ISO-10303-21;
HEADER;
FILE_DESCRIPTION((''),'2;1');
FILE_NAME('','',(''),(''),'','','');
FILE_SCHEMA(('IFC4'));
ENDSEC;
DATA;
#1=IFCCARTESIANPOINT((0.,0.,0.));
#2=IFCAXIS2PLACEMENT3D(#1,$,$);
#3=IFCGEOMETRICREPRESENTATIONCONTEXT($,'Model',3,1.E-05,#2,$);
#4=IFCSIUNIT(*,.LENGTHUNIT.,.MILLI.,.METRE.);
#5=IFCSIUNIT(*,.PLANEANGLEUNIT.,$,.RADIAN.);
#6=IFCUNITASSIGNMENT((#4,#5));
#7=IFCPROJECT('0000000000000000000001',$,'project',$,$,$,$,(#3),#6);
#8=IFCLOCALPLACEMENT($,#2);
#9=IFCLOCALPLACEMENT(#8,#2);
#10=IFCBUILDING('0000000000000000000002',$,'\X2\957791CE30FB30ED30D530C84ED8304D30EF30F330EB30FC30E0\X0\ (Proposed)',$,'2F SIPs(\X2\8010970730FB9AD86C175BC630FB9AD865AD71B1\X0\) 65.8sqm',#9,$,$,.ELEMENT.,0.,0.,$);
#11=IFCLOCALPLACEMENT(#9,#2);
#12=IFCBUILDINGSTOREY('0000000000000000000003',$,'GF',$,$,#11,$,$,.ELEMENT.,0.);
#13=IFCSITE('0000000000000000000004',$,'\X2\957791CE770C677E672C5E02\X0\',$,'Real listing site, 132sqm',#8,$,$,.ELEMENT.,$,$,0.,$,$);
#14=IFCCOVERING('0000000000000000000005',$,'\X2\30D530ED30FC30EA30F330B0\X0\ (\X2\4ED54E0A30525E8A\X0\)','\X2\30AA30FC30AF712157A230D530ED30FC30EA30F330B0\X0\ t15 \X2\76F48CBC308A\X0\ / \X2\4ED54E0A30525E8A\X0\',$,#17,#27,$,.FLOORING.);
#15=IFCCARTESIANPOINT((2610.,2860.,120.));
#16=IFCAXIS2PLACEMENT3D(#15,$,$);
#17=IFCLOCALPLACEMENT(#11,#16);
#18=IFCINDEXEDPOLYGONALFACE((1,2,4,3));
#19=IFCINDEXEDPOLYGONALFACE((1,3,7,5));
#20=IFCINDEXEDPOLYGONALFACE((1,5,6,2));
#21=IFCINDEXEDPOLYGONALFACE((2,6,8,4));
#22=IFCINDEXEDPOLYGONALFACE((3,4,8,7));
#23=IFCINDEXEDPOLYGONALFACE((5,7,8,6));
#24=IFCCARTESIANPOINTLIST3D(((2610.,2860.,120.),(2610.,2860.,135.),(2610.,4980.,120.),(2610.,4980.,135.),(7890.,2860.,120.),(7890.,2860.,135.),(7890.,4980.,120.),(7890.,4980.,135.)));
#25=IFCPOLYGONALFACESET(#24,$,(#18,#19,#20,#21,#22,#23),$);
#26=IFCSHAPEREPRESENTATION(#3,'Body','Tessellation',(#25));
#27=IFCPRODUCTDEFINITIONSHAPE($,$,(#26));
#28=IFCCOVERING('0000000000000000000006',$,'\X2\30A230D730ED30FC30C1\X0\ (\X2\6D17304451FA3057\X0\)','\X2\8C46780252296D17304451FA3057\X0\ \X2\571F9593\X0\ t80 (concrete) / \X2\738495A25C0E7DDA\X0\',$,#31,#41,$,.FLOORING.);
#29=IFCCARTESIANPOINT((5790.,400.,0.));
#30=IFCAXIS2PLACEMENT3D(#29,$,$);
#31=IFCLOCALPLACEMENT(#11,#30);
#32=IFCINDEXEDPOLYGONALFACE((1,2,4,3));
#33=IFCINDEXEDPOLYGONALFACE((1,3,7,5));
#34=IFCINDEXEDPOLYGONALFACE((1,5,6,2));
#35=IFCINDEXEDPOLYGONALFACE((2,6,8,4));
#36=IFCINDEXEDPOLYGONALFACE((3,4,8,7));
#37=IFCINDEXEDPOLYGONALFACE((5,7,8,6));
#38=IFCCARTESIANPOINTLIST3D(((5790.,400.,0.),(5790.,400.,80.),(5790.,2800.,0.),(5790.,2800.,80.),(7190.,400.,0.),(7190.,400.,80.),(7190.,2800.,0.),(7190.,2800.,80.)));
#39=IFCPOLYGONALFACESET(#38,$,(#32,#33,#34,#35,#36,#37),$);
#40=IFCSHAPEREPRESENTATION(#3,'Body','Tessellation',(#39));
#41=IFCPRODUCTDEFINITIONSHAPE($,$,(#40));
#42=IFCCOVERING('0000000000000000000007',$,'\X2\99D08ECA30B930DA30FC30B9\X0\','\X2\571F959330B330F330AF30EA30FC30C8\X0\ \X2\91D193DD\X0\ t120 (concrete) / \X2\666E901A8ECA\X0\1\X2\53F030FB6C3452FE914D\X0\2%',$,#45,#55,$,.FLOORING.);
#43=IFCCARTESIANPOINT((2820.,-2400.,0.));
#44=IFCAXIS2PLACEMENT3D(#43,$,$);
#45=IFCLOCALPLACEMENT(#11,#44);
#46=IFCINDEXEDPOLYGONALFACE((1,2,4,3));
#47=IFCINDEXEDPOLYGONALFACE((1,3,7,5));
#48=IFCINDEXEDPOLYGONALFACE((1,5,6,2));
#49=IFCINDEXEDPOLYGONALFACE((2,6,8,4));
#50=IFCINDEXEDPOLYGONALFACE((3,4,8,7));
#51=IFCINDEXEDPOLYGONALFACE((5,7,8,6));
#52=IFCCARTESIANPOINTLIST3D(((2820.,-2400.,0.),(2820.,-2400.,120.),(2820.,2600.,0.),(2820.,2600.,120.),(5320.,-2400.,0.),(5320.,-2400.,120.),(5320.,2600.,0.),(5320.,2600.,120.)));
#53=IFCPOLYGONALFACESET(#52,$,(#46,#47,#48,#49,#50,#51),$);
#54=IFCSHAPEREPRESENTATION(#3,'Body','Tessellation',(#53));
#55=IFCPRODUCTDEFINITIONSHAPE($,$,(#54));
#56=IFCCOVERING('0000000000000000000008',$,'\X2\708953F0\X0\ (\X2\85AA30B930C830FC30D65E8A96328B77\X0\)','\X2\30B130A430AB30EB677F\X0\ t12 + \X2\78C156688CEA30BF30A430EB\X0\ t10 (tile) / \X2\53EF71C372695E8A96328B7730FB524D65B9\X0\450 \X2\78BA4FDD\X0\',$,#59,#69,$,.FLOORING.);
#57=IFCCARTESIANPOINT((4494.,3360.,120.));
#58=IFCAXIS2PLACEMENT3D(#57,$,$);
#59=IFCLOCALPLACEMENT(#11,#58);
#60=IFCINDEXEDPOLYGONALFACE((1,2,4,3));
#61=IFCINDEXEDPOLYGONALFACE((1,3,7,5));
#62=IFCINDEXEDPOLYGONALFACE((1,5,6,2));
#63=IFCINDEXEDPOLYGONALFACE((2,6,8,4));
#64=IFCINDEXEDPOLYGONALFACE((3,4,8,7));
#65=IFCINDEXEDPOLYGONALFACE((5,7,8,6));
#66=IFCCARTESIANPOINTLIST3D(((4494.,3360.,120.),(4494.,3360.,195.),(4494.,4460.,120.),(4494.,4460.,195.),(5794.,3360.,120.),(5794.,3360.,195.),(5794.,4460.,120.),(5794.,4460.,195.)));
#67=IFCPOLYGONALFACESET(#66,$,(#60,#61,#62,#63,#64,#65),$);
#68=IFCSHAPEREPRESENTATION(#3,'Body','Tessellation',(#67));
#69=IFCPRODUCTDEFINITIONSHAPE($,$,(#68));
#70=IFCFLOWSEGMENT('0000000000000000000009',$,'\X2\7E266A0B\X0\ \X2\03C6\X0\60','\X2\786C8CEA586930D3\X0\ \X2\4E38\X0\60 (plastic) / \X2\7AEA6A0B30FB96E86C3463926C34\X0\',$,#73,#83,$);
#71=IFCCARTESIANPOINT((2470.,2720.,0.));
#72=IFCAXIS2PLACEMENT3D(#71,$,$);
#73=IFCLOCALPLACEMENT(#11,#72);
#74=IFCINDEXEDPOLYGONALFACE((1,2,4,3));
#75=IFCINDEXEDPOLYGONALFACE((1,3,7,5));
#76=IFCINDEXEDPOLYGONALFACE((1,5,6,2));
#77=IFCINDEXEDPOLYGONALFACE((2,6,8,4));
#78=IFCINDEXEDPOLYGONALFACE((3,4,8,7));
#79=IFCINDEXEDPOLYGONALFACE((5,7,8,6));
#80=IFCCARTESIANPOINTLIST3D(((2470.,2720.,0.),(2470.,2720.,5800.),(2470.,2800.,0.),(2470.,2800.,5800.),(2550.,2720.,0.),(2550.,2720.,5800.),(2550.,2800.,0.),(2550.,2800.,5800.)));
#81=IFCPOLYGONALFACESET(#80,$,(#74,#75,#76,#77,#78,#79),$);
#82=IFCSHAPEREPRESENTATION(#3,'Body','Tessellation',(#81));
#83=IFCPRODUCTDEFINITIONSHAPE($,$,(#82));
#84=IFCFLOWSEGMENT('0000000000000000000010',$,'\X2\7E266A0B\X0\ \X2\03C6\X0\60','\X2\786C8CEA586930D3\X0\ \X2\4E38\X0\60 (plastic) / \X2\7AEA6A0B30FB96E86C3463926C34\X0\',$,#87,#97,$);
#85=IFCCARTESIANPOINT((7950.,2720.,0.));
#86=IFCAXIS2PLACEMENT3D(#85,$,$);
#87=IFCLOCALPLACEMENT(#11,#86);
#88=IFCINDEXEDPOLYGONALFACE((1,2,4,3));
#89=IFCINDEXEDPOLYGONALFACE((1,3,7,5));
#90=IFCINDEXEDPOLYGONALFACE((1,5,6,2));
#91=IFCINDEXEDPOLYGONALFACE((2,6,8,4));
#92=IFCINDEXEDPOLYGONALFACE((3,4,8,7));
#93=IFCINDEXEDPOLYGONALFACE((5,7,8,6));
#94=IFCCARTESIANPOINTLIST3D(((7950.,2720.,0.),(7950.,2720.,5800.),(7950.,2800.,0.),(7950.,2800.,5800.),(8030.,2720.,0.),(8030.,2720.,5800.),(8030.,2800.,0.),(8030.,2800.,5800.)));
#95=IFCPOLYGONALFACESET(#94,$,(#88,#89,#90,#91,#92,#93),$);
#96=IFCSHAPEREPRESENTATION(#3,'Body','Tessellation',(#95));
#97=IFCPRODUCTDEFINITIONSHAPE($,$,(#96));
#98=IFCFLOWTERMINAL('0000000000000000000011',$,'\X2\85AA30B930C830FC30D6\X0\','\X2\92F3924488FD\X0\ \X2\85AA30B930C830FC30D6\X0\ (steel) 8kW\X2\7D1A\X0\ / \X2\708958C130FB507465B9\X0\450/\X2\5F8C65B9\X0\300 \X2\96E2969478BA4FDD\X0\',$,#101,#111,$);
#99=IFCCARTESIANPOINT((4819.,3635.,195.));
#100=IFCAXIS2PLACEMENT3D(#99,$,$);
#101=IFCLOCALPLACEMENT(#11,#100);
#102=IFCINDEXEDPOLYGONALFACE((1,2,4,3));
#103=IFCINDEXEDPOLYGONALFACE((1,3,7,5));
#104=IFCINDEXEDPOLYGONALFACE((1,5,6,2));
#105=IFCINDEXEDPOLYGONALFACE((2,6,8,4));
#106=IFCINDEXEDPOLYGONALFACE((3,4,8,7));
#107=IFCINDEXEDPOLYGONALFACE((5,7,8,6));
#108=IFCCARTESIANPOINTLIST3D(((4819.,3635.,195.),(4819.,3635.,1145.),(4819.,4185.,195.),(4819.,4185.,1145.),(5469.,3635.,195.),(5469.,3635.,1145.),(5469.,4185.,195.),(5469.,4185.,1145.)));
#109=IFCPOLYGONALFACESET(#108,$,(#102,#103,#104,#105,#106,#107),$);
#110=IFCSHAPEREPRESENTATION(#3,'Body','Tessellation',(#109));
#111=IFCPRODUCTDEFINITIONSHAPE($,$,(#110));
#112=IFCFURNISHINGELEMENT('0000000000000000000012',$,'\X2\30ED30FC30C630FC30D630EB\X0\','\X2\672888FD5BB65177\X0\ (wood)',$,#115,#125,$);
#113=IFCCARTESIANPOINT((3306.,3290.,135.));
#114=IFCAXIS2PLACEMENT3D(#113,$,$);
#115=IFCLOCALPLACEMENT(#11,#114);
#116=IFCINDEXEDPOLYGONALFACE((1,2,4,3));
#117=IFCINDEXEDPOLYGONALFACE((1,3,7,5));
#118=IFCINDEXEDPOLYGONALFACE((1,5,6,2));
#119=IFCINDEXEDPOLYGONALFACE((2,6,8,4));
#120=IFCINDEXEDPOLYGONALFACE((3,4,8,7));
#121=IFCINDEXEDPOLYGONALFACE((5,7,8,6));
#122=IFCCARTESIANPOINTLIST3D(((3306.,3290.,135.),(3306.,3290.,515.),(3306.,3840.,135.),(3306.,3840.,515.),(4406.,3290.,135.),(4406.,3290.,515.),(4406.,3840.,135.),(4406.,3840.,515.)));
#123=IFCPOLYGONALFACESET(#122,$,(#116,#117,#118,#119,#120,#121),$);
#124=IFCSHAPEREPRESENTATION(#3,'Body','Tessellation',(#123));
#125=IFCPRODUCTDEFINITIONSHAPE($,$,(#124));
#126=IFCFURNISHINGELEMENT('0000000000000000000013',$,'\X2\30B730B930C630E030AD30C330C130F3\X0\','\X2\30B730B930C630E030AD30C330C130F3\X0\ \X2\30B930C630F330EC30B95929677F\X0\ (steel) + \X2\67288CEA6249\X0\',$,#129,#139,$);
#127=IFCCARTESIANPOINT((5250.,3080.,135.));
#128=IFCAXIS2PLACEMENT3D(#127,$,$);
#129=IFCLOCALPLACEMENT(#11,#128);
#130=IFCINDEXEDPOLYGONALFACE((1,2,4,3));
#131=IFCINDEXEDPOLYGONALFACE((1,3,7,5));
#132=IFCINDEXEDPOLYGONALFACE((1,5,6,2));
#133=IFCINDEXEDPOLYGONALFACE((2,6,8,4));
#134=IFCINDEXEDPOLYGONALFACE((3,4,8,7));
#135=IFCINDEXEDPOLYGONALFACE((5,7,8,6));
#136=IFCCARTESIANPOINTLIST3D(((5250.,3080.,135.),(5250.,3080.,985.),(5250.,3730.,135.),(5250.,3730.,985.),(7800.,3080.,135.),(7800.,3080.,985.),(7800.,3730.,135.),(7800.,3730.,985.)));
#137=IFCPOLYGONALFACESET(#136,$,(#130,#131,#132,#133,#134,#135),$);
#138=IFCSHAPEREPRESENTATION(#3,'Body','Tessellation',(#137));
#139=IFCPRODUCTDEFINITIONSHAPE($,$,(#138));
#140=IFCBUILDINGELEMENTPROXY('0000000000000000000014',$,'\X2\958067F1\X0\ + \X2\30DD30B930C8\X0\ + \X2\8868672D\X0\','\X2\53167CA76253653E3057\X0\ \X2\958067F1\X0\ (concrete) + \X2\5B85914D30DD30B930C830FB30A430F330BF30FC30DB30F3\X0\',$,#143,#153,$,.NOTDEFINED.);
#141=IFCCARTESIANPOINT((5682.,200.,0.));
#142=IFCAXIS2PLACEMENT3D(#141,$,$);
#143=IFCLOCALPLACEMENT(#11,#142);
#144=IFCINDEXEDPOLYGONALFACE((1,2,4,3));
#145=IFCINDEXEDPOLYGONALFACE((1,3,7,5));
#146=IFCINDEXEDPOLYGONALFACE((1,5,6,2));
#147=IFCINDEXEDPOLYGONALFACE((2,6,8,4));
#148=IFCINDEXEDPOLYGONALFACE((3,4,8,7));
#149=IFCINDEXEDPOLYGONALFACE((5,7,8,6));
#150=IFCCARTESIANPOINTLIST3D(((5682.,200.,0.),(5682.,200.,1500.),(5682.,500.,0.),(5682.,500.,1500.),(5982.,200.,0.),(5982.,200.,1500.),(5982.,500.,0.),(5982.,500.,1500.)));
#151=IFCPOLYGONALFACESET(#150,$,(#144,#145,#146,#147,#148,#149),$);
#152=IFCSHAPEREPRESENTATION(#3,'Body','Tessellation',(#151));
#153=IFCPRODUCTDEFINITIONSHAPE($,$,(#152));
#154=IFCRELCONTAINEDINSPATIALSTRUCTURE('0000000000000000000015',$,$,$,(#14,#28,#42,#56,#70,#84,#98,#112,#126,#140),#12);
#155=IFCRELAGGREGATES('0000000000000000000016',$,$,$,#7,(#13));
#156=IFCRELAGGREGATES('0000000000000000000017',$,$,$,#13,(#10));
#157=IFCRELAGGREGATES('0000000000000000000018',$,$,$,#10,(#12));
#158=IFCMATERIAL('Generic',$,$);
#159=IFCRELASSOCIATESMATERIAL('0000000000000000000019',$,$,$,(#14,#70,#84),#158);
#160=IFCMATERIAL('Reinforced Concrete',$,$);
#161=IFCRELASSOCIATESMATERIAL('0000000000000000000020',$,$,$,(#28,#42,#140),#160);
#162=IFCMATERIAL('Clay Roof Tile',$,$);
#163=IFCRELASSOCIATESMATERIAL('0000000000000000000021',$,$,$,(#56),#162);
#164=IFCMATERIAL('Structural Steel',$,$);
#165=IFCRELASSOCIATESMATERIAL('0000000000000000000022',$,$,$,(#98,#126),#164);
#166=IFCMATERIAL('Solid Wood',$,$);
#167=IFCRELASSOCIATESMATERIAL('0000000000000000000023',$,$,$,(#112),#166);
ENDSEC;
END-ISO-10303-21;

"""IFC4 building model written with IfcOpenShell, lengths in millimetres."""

from ifc_helpers import new_model, si_unit, frame, frame_2d, origin, place, context, project, spatial, rectangle, extrude, material, element, save


model = new_model("IFC4")

# Units and contexts
model_context = context("Model", 3, precision=1e-05, world=origin())
ifc_project = project(units=[si_unit("LENGTHUNIT", "METRE", prefix="MILLI"), si_unit("PLANEANGLEUNIT", "RADIAN")], contexts=[model_context])

# Site, building, storey
site_placement = place(None, origin())
site = spatial("IfcSite", under=ifc_project, at=site_placement, Name="長野県松本市", ObjectType="Real listing site, 132sqm", CompositionType="ELEMENT", RefElevation=0.0)
building_placement = place(site_placement, origin())
building = spatial("IfcBuilding", under=site, at=building_placement, Name="長野・ロフト付きワンルーム (Proposed)", ObjectType="2F SIPs(耐震・高気密・高断熱) 65.8sqm", CompositionType="ELEMENT", ElevationOfRefHeight=0.0, ElevationOfTerrain=0.0)
storey_placement = place(building_placement, origin())
storey = spatial("IfcBuildingStorey", under=building, at=storey_placement, Name="GF", CompositionType="ELEMENT", Elevation=0.0)

# Shared definitions
ifc_material_1 = material(Name="Solid Wood")

# Shared definitions
ifc_material_2 = material(Name="Reinforced Concrete")

# Coverings
ifc_material_3 = material(Name="Generic")
covering_1_placement = place(storey_placement, frame((2610.0, 2860.0, 120.0)))
element("IfcCovering", 1, at=covering_1_placement, inside=storey, material=ifc_material_3, Name="フローリング (仕上げ床)", Description="オーク無垢フローリング t15 直貼り / 仕上げ床", PredefinedType="FLOORING", context=model_context, shape_type="SweptSolid", body=[
    extrude(rectangle(XDim=5280.0, YDim=2120.0, at=frame_2d((2640.0, 1060.0))), frame((2610.0, 2860.0, 120.0)), (0.0, 0.0, 1.0), 15.0),
])
covering_2_placement = place(storey_placement, frame((5790.0, 400.0, 0.0)))
element("IfcCovering", 2, at=covering_2_placement, inside=storey, material=ifc_material_2, Name="アプローチ (洗い出し)", Description="豆砂利洗い出し 土間 t80 (concrete) / 玄関導線", PredefinedType="FLOORING", context=model_context, shape_type="SweptSolid", body=[
    extrude(rectangle(XDim=1400.0, YDim=2400.0, at=frame_2d((700.0, 1200.0))), frame((5790.0, 400.0, 0.0)), (0.0, 0.0, 1.0), 80.0),
])
covering_3_placement = place(storey_placement, frame((2820.0, -2400.0, 0.0)))
element("IfcCovering", 3, at=covering_3_placement, inside=storey, material=ifc_material_2, Name="駐車スペース", Description="土間コンクリート 金鏝 t120 (concrete) / 普通車1台・水勾配2%", PredefinedType="FLOORING", context=model_context, shape_type="SweptSolid", body=[
    extrude(rectangle(XDim=2500.0, YDim=5000.0, at=frame_2d((1250.0, 2500.0))), frame((2820.0, -2400.0, 0.0)), (0.0, 0.0, 1.0), 120.0),
])
ifc_material_4 = material(Name="Clay Roof Tile")
covering_4_placement = place(storey_placement, frame((4494.0, 3360.0, 120.0)))
element("IfcCovering", 4, at=covering_4_placement, inside=storey, material=ifc_material_4, Name="炉台 (薪ストーブ床防護)", Description="ケイカル板 t12 + 磁器質タイル t10 (tile) / 可燃物床防護・前方450 確保", PredefinedType="FLOORING", context=model_context, shape_type="SweptSolid", body=[
    extrude(rectangle(XDim=1300.0, YDim=1100.0, at=frame_2d((650.0, 550.0))), frame((4494.0, 3360.0, 120.0)), (0.0, 0.0, 1.0), 75.0),
])

# Flow segments
flow_segment_1_placement = place(storey_placement, frame((2470.0, 2720.0, 0.0)))
element("IfcFlowSegment", 5, at=flow_segment_1_placement, inside=storey, material=ifc_material_3, Name="縦樋 φ60", Description="硬質塩ビ 丸60 (plastic) / 竪樋・雨水排水", context=model_context, shape_type="SweptSolid", body=[
    extrude(rectangle(XDim=80.0, YDim=80.0, at=frame_2d((40.0, 40.0))), frame((2470.0, 2720.0, 0.0)), (0.0, 0.0, 1.0), 5800.0),
])
flow_segment_2_placement = place(storey_placement, frame((7950.0, 2720.0, 0.0)))
element("IfcFlowSegment", 6, at=flow_segment_2_placement, inside=storey, material=ifc_material_3, Name="縦樋 φ60", Description="硬質塩ビ 丸60 (plastic) / 竪樋・雨水排水", context=model_context, shape_type="SweptSolid", body=[
    extrude(rectangle(XDim=80.0, YDim=80.0, at=frame_2d((40.0, 40.0))), frame((7950.0, 2720.0, 0.0)), (0.0, 0.0, 1.0), 5800.0),
])

# Flow terminal
ifc_material_5 = material(Name="Structural Steel")
flow_terminal_placement = place(storey_placement, frame((4819.0, 3635.0, 195.0)))
element("IfcFlowTerminal", 7, at=flow_terminal_placement, inside=storey, material=ifc_material_5, Name="薪ストーブ", Description="鋳鉄製 薪ストーブ (steel) 8kW級 / 炉壁・側方450/後方300 離隔確保", context=model_context, shape_type="SweptSolid", body=[
    extrude(rectangle(XDim=650.0, YDim=550.0, at=frame_2d((325.0, 275.0))), frame((4819.0, 3635.0, 195.0)), (0.0, 0.0, 1.0), 950.0),
])

# Furnishing elements
furnishing_1_placement = place(storey_placement, frame((3306.0, 3290.0, 135.0)))
element("IfcFurnishingElement", 8, at=furnishing_1_placement, inside=storey, material=ifc_material_1, Name="ローテーブル", Description="木製家具 (wood)", context=model_context, shape_type="SweptSolid", body=[
    extrude(rectangle(XDim=1100.0, YDim=550.0, at=frame_2d((550.0, 275.0))), frame((3306.0, 3290.0, 135.0)), (0.0, 0.0, 1.0), 380.0),
])
furnishing_2_placement = place(storey_placement, frame((5250.0, 3080.0, 135.0)))
element("IfcFurnishingElement", 9, at=furnishing_2_placement, inside=storey, material=ifc_material_5, Name="システムキッチン", Description="システムキッチン ステンレス天板 (steel) + 木質扉", context=model_context, shape_type="SweptSolid", body=[
    extrude(rectangle(XDim=2550.0, YDim=650.0, at=frame_2d((1275.0, 325.0))), frame((5250.0, 3080.0, 135.0)), (0.0, 0.0, 1.0), 850.0),
])

# Building element proxy
proxy_placement = place(storey_placement, frame((5682.0, 200.0, 0.0)))
element("IfcBuildingElementProxy", 10, at=proxy_placement, inside=storey, material=ifc_material_2, Name="門柱 + ポスト + 表札", Description="化粧打放し 門柱 (concrete) + 宅配ポスト・インターホン", PredefinedType="NOTDEFINED", context=model_context, shape_type="SweptSolid", body=[
    extrude(rectangle(XDim=300.0, YDim=300.0, at=frame_2d((150.0, 150.0))), frame((5682.0, 200.0, 0.0)), (0.0, 0.0, 1.0), 1500.0),
])

save(model, "model.ifc")
